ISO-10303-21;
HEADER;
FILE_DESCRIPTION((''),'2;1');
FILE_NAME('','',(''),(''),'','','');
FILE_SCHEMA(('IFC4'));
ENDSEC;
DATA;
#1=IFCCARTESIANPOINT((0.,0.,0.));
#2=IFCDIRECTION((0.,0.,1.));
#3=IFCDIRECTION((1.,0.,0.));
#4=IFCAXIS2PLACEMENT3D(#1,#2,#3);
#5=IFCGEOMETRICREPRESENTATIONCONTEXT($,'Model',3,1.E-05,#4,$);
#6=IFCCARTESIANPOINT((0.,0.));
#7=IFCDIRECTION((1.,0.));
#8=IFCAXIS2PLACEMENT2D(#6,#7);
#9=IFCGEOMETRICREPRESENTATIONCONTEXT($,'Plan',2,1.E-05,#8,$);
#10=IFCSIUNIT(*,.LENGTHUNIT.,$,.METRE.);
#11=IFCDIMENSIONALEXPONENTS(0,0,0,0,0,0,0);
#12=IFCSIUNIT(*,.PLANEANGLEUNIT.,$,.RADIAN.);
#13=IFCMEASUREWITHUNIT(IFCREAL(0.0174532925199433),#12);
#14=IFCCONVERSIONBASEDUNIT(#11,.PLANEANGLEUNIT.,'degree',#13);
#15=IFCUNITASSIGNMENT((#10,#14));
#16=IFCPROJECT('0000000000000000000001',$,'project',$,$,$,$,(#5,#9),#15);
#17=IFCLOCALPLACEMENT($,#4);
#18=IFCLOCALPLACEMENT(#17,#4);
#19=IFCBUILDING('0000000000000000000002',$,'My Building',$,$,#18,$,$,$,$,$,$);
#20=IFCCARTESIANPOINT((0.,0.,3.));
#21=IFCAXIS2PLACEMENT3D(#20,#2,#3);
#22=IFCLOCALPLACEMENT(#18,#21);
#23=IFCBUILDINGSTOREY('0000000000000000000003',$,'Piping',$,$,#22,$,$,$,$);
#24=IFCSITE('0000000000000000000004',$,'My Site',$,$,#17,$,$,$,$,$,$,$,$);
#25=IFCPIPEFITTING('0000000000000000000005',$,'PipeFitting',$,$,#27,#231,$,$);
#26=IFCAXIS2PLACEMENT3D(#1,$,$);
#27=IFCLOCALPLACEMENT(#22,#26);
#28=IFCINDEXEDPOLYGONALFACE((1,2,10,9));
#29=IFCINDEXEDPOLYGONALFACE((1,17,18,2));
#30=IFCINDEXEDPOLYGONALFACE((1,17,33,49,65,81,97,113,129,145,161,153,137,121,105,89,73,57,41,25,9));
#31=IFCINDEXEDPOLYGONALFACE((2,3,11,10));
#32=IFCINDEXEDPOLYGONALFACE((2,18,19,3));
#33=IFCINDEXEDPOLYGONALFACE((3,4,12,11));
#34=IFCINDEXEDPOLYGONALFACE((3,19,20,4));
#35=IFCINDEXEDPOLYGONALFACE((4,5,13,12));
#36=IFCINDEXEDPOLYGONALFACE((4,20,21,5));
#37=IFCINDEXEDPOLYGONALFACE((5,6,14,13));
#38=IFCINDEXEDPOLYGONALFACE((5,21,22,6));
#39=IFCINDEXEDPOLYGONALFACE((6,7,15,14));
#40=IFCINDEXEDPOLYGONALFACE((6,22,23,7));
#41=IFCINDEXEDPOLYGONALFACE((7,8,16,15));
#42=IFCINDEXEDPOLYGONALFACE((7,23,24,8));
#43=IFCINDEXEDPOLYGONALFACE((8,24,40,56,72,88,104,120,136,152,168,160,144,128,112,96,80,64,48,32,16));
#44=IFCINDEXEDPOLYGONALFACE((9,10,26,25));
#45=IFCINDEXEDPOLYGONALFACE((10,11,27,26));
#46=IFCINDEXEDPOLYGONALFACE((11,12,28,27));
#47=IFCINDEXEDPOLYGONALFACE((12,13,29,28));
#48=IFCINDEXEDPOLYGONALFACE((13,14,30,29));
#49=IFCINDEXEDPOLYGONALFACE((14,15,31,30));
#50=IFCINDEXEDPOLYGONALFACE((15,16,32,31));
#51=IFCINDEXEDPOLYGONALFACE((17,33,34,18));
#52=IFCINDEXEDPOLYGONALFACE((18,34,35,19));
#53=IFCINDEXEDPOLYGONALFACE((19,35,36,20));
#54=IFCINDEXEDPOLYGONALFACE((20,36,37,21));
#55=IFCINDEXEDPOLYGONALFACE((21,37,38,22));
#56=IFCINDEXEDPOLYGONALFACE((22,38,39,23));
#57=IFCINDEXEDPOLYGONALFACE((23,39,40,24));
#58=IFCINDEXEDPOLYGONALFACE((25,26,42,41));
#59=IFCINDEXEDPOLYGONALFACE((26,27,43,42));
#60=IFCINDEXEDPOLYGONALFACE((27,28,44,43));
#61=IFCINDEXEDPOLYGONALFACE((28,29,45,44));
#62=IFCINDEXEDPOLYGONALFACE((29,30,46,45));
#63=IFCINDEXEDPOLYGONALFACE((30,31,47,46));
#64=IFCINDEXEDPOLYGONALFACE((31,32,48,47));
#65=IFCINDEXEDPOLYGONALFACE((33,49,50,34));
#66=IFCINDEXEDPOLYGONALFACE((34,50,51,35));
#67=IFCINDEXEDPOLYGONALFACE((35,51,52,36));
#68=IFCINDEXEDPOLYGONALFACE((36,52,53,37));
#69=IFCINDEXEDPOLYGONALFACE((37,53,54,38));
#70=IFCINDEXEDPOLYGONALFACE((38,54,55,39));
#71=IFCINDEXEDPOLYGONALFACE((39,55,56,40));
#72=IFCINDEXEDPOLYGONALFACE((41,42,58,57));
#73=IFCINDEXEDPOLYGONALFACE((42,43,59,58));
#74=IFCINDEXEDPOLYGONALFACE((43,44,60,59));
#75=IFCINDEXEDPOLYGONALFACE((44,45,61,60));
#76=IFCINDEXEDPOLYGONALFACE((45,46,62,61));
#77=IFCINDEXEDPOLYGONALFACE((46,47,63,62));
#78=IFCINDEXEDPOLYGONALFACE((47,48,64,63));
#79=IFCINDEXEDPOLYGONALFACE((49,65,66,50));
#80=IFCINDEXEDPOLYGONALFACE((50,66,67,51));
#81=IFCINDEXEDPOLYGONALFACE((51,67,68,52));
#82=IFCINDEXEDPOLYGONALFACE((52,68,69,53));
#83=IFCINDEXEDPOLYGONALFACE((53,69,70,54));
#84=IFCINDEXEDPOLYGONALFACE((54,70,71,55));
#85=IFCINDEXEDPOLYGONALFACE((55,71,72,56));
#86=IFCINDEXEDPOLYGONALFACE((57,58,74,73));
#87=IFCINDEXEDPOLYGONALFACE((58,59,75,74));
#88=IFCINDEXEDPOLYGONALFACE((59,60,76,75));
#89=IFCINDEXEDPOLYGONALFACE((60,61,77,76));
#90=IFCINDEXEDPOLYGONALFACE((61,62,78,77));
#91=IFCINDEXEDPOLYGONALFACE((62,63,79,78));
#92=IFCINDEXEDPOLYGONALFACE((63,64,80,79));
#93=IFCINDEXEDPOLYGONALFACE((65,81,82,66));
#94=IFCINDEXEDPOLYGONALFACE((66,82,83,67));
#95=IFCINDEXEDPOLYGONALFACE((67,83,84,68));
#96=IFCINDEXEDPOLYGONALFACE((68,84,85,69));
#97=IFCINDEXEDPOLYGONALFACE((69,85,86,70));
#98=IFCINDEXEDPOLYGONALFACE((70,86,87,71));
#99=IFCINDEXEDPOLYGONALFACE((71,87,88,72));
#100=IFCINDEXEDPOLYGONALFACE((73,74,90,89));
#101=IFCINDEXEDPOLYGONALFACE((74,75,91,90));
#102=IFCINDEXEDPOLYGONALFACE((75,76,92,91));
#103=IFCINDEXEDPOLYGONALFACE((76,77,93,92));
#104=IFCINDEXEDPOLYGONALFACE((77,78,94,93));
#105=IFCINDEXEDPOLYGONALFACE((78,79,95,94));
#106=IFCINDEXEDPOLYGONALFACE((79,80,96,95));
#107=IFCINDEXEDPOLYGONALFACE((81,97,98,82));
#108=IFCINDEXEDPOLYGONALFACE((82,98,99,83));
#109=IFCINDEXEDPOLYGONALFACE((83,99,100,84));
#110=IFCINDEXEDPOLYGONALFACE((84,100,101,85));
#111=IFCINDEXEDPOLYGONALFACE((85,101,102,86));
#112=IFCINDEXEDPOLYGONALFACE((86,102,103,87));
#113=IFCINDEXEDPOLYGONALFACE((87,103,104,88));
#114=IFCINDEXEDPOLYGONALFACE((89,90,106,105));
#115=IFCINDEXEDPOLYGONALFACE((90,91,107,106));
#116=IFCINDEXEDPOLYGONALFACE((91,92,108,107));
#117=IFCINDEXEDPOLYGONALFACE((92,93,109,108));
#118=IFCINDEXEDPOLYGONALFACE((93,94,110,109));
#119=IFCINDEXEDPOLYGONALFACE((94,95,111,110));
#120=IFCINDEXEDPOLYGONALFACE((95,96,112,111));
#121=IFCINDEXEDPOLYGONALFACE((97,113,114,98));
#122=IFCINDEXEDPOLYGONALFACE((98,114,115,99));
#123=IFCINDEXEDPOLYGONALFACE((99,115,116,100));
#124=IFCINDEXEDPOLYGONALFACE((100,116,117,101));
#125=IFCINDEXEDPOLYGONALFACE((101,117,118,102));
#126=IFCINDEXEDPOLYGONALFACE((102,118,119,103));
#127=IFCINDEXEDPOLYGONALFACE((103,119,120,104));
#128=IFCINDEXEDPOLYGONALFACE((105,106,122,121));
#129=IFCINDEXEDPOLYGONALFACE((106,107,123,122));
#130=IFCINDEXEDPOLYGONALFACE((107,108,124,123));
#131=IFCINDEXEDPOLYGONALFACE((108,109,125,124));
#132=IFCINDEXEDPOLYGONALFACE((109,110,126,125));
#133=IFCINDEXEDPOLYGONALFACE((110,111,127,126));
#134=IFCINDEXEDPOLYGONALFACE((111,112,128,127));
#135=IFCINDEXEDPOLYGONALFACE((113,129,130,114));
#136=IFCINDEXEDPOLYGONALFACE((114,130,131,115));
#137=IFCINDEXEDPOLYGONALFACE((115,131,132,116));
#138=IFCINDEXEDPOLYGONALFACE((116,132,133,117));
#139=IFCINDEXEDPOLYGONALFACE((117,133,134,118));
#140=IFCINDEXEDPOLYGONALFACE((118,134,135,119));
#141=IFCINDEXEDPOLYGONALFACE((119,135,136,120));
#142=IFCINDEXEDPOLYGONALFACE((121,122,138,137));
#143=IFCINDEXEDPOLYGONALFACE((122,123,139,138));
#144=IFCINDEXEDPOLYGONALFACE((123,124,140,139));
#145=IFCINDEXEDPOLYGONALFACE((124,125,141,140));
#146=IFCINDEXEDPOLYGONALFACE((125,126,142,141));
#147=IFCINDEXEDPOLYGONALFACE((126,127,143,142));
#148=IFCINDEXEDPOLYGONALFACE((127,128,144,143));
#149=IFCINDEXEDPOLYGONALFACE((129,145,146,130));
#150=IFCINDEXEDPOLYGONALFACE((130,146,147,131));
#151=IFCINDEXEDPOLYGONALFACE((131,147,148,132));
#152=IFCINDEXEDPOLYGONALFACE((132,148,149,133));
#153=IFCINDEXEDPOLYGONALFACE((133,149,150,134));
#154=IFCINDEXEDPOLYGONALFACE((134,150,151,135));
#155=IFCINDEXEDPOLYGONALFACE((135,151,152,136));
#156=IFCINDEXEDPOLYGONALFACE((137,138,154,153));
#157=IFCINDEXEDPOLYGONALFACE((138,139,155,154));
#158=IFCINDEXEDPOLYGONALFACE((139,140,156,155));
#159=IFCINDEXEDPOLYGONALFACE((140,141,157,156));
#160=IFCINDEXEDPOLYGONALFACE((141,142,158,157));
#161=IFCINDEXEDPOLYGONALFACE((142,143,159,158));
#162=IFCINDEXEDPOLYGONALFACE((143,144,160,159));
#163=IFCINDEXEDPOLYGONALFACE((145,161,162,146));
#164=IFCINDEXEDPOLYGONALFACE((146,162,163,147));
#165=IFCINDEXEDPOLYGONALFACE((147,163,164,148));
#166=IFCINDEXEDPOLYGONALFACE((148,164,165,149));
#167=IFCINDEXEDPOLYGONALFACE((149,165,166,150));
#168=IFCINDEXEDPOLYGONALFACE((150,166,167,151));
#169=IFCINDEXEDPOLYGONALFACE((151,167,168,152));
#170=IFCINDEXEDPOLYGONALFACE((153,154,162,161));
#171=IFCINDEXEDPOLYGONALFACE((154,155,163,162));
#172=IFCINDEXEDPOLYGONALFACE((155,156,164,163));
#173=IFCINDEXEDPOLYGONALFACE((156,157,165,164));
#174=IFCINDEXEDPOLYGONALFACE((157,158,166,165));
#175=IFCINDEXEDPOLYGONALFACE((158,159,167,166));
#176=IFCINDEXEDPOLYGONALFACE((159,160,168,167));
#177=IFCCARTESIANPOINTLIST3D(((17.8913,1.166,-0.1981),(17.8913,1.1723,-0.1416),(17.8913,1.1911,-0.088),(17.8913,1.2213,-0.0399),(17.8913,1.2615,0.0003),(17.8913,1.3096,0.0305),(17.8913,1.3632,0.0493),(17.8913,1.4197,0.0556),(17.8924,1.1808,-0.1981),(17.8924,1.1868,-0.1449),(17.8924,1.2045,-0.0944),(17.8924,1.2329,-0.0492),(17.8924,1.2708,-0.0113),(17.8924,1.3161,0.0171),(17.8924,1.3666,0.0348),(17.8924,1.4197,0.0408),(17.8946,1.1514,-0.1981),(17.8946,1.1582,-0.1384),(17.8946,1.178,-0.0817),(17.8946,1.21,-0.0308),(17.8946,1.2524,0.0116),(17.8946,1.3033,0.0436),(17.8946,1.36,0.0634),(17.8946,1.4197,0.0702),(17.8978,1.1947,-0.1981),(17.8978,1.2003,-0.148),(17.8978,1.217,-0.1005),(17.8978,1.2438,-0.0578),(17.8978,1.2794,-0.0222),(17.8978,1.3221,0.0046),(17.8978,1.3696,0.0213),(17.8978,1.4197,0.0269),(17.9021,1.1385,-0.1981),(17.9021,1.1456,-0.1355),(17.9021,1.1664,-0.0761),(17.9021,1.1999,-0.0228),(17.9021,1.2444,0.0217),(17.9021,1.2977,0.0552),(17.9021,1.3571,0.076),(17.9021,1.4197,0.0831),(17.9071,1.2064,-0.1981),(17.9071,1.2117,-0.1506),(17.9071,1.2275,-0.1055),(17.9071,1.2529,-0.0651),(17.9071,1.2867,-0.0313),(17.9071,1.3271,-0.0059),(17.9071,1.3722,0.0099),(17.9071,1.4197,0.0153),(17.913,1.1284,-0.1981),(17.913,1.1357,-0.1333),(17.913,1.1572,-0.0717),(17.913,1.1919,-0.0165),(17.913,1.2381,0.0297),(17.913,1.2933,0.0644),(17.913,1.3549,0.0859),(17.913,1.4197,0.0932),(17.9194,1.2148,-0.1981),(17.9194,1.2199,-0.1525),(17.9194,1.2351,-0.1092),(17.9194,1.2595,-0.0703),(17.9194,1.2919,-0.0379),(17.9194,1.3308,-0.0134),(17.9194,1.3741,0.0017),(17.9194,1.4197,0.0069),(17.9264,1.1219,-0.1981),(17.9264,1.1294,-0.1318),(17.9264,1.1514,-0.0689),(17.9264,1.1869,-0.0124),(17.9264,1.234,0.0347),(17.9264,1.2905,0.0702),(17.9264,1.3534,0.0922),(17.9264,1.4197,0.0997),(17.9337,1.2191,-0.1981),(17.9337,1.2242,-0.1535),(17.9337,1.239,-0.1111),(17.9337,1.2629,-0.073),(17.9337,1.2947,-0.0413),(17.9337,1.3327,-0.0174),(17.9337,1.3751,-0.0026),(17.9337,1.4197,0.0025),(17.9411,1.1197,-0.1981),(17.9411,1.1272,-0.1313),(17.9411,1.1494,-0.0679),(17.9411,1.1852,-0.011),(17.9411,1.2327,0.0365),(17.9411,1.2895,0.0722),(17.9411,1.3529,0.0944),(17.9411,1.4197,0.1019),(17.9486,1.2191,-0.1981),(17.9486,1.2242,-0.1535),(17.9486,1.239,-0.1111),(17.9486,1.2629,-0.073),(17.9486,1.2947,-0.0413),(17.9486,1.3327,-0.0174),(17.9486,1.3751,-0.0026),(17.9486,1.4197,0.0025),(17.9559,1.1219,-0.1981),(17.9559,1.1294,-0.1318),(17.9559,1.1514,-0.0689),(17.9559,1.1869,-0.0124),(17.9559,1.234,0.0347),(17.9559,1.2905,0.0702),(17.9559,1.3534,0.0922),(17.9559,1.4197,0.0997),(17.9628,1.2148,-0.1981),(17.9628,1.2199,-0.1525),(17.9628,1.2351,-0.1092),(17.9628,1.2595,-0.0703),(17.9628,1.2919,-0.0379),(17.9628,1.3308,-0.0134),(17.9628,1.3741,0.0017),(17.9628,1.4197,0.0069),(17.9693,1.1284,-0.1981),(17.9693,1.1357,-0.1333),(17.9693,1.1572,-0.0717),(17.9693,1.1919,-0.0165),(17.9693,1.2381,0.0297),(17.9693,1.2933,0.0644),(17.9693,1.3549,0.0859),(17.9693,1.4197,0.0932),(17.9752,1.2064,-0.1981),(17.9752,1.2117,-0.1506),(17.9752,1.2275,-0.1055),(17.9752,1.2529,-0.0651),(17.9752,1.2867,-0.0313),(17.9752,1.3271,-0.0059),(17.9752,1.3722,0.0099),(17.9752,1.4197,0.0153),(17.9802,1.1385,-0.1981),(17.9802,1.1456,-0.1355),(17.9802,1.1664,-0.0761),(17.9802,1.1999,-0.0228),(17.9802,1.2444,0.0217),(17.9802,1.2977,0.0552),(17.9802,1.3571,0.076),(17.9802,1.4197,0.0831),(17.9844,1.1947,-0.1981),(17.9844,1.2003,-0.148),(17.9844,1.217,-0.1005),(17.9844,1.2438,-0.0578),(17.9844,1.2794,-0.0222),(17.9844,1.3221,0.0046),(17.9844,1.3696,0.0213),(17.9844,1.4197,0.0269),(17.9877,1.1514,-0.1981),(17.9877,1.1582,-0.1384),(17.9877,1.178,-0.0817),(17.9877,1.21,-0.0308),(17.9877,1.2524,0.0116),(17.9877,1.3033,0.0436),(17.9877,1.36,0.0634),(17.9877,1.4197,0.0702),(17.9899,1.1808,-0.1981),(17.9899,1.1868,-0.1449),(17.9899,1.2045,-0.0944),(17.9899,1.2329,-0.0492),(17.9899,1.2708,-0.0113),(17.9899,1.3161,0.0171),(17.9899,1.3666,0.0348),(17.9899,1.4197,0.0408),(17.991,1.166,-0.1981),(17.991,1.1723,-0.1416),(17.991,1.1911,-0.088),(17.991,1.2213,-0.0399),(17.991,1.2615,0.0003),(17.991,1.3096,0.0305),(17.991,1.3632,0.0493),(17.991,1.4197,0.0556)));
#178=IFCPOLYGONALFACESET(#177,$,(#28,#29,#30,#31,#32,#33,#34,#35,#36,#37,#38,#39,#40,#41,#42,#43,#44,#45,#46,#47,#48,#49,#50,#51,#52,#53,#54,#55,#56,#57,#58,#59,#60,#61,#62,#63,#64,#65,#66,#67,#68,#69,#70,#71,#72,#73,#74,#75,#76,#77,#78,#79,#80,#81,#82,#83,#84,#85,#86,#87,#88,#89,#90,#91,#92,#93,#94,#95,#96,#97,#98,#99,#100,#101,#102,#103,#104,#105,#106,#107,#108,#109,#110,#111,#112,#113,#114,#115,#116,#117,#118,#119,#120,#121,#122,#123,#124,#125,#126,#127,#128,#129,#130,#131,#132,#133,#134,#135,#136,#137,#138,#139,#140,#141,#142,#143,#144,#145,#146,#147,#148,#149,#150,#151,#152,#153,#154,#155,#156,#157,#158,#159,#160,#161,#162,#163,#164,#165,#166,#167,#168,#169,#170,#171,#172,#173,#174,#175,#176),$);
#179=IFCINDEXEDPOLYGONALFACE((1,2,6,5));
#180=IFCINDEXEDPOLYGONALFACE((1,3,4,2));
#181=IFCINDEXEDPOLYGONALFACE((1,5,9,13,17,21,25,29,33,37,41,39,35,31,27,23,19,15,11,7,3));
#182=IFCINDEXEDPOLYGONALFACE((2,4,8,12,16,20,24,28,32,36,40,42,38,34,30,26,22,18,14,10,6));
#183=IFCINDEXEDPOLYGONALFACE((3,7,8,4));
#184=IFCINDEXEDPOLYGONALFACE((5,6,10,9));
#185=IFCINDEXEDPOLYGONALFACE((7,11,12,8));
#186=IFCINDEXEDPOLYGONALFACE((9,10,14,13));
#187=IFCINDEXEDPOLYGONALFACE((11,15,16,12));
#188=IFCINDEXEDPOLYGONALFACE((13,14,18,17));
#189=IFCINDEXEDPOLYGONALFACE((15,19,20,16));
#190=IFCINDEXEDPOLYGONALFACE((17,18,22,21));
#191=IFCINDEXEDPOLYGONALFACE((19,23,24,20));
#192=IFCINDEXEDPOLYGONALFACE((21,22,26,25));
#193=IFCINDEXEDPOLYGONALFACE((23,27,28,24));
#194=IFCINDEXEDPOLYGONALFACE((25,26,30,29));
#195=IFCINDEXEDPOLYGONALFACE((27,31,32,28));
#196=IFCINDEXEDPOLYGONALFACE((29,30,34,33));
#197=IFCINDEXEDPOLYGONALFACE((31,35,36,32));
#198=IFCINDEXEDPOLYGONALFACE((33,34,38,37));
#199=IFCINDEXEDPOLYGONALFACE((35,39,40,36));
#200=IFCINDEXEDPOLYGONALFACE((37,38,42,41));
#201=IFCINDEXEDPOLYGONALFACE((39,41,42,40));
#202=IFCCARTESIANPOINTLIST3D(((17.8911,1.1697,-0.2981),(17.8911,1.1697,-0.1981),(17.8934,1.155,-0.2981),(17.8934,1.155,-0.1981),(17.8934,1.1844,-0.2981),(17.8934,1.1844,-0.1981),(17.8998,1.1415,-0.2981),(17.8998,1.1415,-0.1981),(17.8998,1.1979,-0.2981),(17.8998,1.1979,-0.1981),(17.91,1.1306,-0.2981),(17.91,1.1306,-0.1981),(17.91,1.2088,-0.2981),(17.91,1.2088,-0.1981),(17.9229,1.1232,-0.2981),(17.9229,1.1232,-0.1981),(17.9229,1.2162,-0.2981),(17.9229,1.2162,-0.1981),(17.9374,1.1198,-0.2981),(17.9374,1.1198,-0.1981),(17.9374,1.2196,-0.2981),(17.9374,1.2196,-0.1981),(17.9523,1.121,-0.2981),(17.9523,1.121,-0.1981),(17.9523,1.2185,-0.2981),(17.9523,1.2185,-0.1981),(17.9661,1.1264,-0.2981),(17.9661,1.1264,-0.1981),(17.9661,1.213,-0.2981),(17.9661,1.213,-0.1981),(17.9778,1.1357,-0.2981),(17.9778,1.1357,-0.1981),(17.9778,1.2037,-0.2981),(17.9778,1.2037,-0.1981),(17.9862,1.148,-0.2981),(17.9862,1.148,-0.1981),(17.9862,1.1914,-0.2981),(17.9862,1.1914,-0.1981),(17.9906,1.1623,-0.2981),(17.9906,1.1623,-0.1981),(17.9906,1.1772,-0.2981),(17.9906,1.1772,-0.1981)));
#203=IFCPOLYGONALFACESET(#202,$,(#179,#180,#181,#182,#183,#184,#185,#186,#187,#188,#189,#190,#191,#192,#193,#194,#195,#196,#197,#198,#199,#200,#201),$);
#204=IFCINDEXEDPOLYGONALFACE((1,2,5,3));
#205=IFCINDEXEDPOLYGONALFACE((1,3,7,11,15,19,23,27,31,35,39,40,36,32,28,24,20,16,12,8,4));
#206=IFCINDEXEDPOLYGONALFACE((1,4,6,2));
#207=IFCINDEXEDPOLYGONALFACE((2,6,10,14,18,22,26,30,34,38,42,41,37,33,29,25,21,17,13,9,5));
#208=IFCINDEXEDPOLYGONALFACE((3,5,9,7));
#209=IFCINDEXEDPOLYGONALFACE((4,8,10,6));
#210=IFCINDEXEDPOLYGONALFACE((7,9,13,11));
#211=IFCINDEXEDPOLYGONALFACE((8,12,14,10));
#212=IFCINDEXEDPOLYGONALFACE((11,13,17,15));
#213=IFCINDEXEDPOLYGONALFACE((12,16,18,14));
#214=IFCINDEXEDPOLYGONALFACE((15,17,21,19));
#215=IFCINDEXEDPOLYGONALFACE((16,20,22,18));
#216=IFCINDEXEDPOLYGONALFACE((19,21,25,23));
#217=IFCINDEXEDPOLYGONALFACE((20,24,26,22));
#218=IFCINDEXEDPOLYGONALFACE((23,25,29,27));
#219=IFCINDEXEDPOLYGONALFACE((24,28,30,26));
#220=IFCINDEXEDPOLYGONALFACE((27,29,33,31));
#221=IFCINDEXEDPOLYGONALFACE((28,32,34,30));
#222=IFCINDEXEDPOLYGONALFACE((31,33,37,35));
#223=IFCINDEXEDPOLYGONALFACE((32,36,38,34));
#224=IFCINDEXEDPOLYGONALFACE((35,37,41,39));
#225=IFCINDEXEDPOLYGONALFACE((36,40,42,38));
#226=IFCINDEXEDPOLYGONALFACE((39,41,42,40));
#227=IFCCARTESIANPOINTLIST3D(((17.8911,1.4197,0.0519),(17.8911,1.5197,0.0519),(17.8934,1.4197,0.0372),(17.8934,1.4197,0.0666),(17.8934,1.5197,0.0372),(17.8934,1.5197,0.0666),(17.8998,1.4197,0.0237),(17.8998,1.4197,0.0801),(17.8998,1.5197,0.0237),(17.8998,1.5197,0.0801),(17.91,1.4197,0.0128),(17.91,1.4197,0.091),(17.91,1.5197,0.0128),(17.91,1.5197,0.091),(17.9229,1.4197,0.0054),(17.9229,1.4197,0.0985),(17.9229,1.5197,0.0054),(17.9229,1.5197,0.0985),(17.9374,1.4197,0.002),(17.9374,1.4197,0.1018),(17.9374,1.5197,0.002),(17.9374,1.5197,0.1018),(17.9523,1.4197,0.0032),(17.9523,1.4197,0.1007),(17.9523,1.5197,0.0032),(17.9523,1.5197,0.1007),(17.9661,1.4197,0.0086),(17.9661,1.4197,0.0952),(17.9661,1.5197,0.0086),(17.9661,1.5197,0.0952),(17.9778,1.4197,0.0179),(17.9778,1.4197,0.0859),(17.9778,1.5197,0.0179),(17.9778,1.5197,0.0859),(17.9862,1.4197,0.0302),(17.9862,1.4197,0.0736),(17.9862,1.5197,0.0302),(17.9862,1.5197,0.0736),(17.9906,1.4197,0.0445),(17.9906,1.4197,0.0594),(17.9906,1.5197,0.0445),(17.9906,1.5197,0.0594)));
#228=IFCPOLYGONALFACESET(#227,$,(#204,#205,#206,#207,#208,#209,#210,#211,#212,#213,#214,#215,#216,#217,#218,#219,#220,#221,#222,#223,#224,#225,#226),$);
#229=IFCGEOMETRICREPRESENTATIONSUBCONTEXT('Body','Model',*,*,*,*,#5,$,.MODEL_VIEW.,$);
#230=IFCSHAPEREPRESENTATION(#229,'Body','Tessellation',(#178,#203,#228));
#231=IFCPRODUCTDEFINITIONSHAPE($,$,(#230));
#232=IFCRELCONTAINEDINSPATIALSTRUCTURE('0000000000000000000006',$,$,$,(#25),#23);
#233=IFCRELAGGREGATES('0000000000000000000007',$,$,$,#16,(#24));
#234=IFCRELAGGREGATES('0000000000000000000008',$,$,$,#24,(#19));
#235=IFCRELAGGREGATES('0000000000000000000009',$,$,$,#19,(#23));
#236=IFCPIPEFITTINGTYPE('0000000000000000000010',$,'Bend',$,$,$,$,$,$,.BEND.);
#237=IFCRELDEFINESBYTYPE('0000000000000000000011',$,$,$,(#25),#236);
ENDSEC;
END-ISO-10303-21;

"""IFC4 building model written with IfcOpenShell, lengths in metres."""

from ifc_helpers import new_model, entity, si_unit, converted_unit, frame, origin_with_axes, origin_2d_with_axis, place, context, subcontext, project, spatial, circle, extrude, source, transform, mapped, type_object, type_shapes, element, save


model = new_model("IFC4")

# Units and contexts
model_context = context("Model", 3, precision=1e-05, world=origin_with_axes())
plan_context = context("Plan", 2, precision=1e-05, world=origin_2d_with_axis())
body_context = subcontext(model_context, "Body", "Model", "MODEL_VIEW")
ifc_project = project(units=[si_unit("LENGTHUNIT", "METRE"), converted_unit("PLANEANGLEUNIT", "degree", entity("IfcReal", 0.0174532925199433), si_unit("PLANEANGLEUNIT", "RADIAN"), dimensions=[0, 0, 0, 0, 0, 0, 0])], contexts=[model_context, plan_context])

# Site, building, storey
site_placement = place(None, origin_with_axes())
site = spatial("IfcSite", under=ifc_project, at=site_placement, Name="My Site")
building_placement = place(site_placement, origin_with_axes())
building = spatial("IfcBuilding", under=site, at=building_placement, Name="My Building")
storey_placement = place(building_placement, frame((0.0, 0.0, 3.0), z_axis=(0.0, 0.0, 1.0), x_axis=(1.0, 0.0, 0.0)))
storey = spatial("IfcBuildingStorey", under=building, at=storey_placement, Name="Piping")

# Pipe fitting
pipe_fitting_type_1 = type_object("IfcPipeFittingType", Name="Bend", PredefinedType="BEND")
shared_shape = source(origin_with_axes(), body_context, "Body", "SolidModel", [
    entity("IfcSweptDiskSolid", entity("IfcIndexedPolyCurve", entity("IfcCartesianPointList3D", [[0.0, 0.0, 0.1], [0.0, -0.0732, 0.2768], [0.0, -0.25, 0.35]]), [entity("IfcArcIndex", [1, 2, 3])]), 0.05),
    extrude(circle(Radius=0.05), origin_with_axes(), (0.0, 0.0, 1.0), 0.1),
    extrude(circle(Radius=0.05), frame((0.0, -0.25, 0.35), z_axis=(0.0, -1.0, -0.000001), x_axis=(1.0, 0.0, 0.0)), (0.0, 0.0, 1.0), 0.1),
])
type_shapes(pipe_fitting_type_1, [shared_shape])
for number, where, z_axis, x_axis, name in (
    (1, (17.9411, 1.1697, -0.2981), (0.0, 0.0, 1.0), (-1.0, 0.0, 0.0), "PipeFitting"),
):
    element("IfcPipeFitting", number, at=place(storey_placement, frame(where, z_axis=z_axis, x_axis=x_axis)), inside=storey, type_object=pipe_fitting_type_1, Name=name, context=body_context, shape_type="MappedRepresentation", body=[
        mapped(shared_shape, transform((0.0, 0.0, 0.0), x_axis=(1.0, 0.0, 0.0), y_axis=(0.0, 1.0, 0.0), z_axis=(0.0, 0.0, 1.0), scale=1.0)),
    ])

save(model, "model.ifc")
